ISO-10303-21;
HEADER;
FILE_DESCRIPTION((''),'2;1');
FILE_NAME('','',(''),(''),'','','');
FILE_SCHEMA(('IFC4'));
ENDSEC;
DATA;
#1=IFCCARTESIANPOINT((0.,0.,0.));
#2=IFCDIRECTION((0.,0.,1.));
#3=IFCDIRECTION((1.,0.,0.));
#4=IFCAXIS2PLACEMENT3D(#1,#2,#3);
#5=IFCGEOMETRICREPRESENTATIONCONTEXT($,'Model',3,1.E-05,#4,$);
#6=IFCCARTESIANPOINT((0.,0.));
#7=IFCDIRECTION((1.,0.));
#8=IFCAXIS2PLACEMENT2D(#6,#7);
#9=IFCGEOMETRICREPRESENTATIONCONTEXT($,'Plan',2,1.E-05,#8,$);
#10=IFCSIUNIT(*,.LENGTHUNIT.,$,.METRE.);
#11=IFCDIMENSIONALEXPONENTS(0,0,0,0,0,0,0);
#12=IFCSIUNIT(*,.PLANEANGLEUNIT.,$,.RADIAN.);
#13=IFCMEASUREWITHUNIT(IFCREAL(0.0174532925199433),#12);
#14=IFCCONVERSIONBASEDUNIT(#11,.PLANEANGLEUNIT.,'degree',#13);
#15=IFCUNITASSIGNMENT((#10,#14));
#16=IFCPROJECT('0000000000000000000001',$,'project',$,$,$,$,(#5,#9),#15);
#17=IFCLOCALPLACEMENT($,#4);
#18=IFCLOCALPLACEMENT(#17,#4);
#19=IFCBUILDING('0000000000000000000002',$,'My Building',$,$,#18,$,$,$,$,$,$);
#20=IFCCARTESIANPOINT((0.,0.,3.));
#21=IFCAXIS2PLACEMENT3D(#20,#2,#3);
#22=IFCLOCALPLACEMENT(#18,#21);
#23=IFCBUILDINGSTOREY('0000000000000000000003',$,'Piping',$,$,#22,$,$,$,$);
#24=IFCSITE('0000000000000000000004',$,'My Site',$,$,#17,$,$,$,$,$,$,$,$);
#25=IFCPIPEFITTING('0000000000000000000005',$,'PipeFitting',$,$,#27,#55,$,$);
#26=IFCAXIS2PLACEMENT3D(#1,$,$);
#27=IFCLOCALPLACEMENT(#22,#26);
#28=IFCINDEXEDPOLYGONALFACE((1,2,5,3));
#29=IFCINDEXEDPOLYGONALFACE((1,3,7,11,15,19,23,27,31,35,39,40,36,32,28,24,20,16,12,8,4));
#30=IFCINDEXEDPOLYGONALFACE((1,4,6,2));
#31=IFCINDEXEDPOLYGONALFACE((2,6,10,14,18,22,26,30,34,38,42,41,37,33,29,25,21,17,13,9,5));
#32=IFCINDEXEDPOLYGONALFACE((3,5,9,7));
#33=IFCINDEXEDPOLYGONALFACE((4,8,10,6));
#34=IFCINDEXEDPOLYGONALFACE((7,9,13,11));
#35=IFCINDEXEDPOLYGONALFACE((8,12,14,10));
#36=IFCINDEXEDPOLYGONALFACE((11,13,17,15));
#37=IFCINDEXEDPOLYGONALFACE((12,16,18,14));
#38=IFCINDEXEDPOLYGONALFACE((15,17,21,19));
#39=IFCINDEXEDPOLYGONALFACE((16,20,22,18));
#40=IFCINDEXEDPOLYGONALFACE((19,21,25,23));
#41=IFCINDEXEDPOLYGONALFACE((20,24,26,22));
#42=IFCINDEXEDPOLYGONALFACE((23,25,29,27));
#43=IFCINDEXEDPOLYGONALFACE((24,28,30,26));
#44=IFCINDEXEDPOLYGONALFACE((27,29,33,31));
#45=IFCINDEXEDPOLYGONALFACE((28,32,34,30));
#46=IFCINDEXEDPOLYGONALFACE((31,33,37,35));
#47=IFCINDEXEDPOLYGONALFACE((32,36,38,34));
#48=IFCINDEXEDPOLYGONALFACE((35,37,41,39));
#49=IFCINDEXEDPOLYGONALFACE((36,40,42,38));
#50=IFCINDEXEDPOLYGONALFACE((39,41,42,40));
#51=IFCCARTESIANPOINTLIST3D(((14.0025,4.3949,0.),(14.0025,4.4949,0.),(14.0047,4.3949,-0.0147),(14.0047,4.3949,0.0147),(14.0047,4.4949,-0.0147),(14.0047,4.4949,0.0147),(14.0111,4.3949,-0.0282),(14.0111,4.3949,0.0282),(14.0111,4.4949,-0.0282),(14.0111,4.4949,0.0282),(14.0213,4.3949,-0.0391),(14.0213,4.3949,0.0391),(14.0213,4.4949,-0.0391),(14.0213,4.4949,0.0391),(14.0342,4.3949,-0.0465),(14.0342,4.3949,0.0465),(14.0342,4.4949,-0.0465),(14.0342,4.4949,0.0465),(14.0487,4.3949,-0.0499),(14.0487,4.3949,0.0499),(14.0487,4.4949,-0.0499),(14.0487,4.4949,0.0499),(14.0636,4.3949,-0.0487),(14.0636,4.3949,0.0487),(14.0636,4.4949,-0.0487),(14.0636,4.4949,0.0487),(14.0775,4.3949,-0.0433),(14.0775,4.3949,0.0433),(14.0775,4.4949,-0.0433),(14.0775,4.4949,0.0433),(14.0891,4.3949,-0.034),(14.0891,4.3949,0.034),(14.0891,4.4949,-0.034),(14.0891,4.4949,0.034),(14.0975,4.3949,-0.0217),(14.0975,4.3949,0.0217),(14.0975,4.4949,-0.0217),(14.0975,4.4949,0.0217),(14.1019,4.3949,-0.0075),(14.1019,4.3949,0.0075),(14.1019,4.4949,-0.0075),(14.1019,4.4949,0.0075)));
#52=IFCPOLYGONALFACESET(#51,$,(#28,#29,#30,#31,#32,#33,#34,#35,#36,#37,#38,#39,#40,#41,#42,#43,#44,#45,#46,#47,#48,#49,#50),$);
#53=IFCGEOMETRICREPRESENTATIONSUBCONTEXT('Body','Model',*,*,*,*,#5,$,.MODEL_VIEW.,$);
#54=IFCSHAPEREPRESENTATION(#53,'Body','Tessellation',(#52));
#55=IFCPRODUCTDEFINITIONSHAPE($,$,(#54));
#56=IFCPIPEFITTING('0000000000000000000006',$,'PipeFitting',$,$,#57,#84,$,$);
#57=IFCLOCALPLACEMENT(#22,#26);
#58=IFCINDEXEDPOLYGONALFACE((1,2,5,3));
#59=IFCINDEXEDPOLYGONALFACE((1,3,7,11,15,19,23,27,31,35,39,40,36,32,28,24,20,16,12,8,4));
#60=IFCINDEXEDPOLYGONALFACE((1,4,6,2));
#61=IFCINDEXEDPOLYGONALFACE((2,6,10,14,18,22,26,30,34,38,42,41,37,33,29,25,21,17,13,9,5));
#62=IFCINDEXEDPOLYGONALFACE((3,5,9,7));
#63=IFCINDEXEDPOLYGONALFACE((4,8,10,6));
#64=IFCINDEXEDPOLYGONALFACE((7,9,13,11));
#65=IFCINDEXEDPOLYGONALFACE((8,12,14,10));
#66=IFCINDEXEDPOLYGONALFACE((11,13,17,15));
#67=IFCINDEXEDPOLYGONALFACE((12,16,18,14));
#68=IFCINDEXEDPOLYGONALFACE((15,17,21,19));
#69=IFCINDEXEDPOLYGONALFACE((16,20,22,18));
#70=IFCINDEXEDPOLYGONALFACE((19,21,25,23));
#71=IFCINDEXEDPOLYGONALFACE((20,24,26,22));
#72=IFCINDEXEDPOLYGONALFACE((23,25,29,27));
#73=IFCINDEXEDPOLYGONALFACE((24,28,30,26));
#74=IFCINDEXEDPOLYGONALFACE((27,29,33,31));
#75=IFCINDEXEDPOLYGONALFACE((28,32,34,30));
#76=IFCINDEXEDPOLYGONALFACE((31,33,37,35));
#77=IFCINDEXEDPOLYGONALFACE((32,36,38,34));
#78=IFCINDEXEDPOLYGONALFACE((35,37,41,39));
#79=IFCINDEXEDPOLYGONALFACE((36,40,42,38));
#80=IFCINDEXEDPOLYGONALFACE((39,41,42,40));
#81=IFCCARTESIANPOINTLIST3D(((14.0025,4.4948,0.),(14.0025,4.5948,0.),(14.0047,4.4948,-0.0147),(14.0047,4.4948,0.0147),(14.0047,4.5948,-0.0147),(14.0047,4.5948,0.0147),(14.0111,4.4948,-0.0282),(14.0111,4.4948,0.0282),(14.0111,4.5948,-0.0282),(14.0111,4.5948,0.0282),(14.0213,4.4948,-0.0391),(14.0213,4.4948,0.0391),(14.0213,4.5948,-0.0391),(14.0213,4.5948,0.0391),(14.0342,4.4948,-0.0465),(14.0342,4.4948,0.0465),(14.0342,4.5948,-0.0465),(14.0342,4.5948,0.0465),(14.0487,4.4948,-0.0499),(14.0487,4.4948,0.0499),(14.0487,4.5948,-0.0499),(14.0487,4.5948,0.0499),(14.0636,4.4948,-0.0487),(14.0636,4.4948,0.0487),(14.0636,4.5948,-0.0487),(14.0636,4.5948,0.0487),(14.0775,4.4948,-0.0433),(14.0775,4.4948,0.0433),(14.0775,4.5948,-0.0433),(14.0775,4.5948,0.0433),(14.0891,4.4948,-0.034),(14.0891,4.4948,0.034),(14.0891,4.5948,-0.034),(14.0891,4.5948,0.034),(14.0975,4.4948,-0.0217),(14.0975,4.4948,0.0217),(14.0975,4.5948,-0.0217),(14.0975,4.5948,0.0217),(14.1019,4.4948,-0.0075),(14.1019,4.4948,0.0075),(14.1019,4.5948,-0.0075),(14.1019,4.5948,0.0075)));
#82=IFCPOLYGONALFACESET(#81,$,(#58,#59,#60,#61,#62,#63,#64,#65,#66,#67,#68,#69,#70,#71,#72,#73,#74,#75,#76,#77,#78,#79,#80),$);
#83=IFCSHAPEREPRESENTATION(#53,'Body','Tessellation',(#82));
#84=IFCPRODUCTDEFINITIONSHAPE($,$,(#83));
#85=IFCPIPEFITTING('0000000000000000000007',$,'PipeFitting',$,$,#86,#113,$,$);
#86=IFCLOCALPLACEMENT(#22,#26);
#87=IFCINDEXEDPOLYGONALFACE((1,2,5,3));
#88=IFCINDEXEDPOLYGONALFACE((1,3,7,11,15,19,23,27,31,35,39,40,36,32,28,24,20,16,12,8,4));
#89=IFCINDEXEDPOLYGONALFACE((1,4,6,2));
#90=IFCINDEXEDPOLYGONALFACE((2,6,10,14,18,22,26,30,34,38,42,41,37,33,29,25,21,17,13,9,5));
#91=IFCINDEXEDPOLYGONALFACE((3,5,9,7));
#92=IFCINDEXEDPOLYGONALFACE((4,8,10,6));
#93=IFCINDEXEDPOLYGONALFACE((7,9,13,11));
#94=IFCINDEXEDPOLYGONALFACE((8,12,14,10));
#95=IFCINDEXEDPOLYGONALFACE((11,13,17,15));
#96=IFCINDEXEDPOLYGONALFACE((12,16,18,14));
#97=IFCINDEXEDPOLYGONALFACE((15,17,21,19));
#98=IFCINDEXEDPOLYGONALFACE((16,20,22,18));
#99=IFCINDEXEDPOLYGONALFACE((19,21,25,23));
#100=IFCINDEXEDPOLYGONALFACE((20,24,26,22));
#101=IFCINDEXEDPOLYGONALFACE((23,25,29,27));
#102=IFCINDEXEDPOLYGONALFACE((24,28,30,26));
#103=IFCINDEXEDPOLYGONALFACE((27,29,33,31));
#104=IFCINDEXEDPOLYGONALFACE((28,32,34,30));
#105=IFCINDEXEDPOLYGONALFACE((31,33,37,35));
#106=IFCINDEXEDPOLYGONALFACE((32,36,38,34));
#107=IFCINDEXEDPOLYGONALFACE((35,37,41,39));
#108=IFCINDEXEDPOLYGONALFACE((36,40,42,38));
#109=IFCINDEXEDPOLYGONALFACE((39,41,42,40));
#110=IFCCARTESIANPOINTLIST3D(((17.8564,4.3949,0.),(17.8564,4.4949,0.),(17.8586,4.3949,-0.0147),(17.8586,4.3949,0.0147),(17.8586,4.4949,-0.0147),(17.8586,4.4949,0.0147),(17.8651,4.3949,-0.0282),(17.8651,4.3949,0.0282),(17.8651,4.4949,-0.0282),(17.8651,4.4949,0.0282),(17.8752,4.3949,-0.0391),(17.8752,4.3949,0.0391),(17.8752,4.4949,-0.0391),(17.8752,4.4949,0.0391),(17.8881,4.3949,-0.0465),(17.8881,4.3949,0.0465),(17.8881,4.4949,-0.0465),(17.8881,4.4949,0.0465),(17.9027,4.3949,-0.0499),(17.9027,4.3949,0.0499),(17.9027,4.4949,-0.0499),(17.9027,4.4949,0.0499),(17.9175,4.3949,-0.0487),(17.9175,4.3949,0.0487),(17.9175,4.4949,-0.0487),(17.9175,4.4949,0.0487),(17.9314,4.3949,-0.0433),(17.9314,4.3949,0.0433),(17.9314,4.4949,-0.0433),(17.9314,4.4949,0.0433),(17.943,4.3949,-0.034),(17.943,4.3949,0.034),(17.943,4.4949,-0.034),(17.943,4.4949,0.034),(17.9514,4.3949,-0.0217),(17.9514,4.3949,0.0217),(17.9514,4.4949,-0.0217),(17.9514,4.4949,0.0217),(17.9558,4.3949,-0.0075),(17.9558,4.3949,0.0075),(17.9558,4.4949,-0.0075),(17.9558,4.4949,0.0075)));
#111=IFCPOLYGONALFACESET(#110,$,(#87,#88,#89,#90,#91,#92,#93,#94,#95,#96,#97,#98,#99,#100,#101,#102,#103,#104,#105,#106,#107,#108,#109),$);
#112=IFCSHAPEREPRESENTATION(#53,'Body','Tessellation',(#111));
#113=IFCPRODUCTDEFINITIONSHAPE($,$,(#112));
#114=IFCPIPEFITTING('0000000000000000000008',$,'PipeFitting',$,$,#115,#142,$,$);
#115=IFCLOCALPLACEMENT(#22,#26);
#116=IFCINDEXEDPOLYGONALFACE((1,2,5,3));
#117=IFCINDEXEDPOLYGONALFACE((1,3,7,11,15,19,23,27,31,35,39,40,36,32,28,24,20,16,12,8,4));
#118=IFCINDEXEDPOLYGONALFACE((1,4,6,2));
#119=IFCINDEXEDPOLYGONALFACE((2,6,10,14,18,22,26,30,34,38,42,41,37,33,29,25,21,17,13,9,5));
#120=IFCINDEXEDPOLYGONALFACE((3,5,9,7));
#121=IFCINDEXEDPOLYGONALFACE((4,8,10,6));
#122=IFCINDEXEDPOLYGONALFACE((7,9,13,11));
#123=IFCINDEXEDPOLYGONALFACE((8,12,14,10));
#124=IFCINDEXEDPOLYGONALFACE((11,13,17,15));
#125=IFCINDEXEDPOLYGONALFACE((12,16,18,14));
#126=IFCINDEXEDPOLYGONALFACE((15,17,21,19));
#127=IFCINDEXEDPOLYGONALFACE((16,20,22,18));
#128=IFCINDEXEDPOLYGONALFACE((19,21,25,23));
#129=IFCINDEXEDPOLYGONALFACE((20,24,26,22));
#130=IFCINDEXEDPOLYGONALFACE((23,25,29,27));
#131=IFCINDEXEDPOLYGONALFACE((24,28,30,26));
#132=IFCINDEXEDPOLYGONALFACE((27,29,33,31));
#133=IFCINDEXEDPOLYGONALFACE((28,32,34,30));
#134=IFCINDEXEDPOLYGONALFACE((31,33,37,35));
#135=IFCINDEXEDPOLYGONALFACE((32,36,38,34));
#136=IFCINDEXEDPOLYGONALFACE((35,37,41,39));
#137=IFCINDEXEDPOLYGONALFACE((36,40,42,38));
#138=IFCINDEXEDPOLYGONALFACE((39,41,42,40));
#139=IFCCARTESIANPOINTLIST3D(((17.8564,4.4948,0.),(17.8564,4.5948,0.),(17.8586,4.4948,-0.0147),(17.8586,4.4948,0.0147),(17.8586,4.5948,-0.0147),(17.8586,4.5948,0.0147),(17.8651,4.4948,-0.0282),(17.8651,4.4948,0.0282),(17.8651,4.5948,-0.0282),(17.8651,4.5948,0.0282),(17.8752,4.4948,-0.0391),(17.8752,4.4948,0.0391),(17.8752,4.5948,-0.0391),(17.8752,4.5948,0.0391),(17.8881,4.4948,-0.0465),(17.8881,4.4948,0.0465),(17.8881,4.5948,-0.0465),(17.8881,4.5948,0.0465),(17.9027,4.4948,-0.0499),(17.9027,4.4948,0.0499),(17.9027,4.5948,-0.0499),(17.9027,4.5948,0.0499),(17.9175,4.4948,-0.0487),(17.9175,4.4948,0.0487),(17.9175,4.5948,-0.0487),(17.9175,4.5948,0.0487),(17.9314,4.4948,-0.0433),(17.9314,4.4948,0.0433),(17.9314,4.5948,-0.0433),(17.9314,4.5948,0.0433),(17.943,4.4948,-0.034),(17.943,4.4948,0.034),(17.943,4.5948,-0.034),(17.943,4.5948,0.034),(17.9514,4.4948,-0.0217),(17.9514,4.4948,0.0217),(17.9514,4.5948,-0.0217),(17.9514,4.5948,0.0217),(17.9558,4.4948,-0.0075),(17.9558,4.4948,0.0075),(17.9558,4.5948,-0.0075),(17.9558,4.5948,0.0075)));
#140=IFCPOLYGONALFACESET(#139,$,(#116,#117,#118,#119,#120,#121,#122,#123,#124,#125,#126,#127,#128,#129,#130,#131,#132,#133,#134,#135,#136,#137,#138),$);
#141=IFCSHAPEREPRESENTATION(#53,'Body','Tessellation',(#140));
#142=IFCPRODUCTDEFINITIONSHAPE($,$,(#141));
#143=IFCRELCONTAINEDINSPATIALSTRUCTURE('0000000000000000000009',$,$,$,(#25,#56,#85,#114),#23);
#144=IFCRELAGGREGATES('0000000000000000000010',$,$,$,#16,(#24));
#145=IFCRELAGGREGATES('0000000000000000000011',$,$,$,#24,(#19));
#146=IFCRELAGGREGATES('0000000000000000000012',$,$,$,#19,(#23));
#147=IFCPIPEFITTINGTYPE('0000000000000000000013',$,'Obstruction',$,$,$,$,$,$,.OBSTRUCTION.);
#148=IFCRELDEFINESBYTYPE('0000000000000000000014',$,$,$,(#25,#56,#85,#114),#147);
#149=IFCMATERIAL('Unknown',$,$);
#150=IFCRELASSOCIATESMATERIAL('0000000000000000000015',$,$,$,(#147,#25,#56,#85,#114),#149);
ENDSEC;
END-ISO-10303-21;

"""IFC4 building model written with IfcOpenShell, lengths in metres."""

from ifc_helpers import new_model, entity, si_unit, converted_unit, frame, origin_with_axes, origin_2d_with_axis, place, context, subcontext, project, spatial, circle, extrude, material, material_profile, profile_set, profile_usage, type_object, element, save


model = new_model("IFC4")

# Units and contexts
model_context = context("Model", 3, precision=1e-05, world=origin_with_axes())
plan_context = context("Plan", 2, precision=1e-05, world=origin_2d_with_axis())
body_context = subcontext(model_context, "Body", "Model", "MODEL_VIEW")
ifc_project = project(units=[si_unit("LENGTHUNIT", "METRE"), converted_unit("PLANEANGLEUNIT", "degree", entity("IfcReal", 0.0174532925199433), si_unit("PLANEANGLEUNIT", "RADIAN"), dimensions=[0, 0, 0, 0, 0, 0, 0])], contexts=[model_context, plan_context])

# Site, building, storey
site_placement = place(None, origin_with_axes())
site = spatial("IfcSite", under=ifc_project, at=site_placement, Name="My Site")
building_placement = place(site_placement, origin_with_axes())
building = spatial("IfcBuilding", under=site, at=building_placement, Name="My Building")
storey_placement = place(building_placement, frame((0.0, 0.0, 3.0), z_axis=(0.0, 0.0, 1.0), x_axis=(1.0, 0.0, 0.0)))
storey = spatial("IfcBuildingStorey", under=building, at=storey_placement, Name="Piping")

# Shared definitions
ifc_material = material(Name="Unknown")

# Pipe fittings
ifc_material_profile_1 = material_profile(ifc_material, circle(Radius=0.05))
ifc_profile_set_1 = profile_set([ifc_material_profile_1])
pipe_fitting_type_1 = type_object("IfcPipeFittingType", Name="Obstruction", PredefinedType="OBSTRUCTION", material=ifc_profile_set_1)
ifc_profile_usage_1 = profile_usage(ifc_profile_set_1, cardinal=5)
pipe_fitting_1_placement = place(storey_placement, frame((14.0525, 4.3949, 0.0), z_axis=(0.0, 1.0, 0.0), x_axis=(-1.0, 0.0, 0.0)))
element("IfcPipeFitting", 1, at=pipe_fitting_1_placement, inside=storey, type_object=pipe_fitting_type_1, material=ifc_profile_usage_1, Name="PipeFitting", context=body_context, shape_type="SweptSolid", body=[
    extrude(circle(Radius=0.05), origin_with_axes(), (0.0, 0.0, 1.0), 0.1),
])
ifc_profile_usage_2 = profile_usage(ifc_profile_set_1, cardinal=5)
pipe_fitting_2_placement = place(storey_placement, frame((14.0525, 4.4948, 0.0), z_axis=(0.0, 1.0, 0.0), x_axis=(-1.0, 0.0, 0.0)))
element("IfcPipeFitting", 2, at=pipe_fitting_2_placement, inside=storey, type_object=pipe_fitting_type_1, material=ifc_profile_usage_2, Name="PipeFitting", context=body_context, shape_type="SweptSolid", body=[
    extrude(circle(Radius=0.05), origin_with_axes(), (0.0, 0.0, 1.0), 0.1),
])
ifc_profile_usage_3 = profile_usage(ifc_profile_set_1, cardinal=5)
pipe_fitting_3_placement = place(storey_placement, frame((17.9064, 4.3949, 0.0), z_axis=(0.0, 1.0, 0.0), x_axis=(-1.0, 0.0, 0.0)))
element("IfcPipeFitting", 3, at=pipe_fitting_3_placement, inside=storey, type_object=pipe_fitting_type_1, material=ifc_profile_usage_3, Name="PipeFitting", context=body_context, shape_type="SweptSolid", body=[
    extrude(circle(Radius=0.05), origin_with_axes(), (0.0, 0.0, 1.0), 0.1),
])
ifc_profile_usage_4 = profile_usage(ifc_profile_set_1, cardinal=5)
pipe_fitting_4_placement = place(storey_placement, frame((17.9064, 4.4948, 0.0), z_axis=(0.0, 1.0, 0.0), x_axis=(-1.0, 0.0, 0.0)))
element("IfcPipeFitting", 4, at=pipe_fitting_4_placement, inside=storey, type_object=pipe_fitting_type_1, material=ifc_profile_usage_4, Name="PipeFitting", context=body_context, shape_type="SweptSolid", body=[
    extrude(circle(Radius=0.05), origin_with_axes(), (0.0, 0.0, 1.0), 0.1),
])

save(model, "model.ifc")
